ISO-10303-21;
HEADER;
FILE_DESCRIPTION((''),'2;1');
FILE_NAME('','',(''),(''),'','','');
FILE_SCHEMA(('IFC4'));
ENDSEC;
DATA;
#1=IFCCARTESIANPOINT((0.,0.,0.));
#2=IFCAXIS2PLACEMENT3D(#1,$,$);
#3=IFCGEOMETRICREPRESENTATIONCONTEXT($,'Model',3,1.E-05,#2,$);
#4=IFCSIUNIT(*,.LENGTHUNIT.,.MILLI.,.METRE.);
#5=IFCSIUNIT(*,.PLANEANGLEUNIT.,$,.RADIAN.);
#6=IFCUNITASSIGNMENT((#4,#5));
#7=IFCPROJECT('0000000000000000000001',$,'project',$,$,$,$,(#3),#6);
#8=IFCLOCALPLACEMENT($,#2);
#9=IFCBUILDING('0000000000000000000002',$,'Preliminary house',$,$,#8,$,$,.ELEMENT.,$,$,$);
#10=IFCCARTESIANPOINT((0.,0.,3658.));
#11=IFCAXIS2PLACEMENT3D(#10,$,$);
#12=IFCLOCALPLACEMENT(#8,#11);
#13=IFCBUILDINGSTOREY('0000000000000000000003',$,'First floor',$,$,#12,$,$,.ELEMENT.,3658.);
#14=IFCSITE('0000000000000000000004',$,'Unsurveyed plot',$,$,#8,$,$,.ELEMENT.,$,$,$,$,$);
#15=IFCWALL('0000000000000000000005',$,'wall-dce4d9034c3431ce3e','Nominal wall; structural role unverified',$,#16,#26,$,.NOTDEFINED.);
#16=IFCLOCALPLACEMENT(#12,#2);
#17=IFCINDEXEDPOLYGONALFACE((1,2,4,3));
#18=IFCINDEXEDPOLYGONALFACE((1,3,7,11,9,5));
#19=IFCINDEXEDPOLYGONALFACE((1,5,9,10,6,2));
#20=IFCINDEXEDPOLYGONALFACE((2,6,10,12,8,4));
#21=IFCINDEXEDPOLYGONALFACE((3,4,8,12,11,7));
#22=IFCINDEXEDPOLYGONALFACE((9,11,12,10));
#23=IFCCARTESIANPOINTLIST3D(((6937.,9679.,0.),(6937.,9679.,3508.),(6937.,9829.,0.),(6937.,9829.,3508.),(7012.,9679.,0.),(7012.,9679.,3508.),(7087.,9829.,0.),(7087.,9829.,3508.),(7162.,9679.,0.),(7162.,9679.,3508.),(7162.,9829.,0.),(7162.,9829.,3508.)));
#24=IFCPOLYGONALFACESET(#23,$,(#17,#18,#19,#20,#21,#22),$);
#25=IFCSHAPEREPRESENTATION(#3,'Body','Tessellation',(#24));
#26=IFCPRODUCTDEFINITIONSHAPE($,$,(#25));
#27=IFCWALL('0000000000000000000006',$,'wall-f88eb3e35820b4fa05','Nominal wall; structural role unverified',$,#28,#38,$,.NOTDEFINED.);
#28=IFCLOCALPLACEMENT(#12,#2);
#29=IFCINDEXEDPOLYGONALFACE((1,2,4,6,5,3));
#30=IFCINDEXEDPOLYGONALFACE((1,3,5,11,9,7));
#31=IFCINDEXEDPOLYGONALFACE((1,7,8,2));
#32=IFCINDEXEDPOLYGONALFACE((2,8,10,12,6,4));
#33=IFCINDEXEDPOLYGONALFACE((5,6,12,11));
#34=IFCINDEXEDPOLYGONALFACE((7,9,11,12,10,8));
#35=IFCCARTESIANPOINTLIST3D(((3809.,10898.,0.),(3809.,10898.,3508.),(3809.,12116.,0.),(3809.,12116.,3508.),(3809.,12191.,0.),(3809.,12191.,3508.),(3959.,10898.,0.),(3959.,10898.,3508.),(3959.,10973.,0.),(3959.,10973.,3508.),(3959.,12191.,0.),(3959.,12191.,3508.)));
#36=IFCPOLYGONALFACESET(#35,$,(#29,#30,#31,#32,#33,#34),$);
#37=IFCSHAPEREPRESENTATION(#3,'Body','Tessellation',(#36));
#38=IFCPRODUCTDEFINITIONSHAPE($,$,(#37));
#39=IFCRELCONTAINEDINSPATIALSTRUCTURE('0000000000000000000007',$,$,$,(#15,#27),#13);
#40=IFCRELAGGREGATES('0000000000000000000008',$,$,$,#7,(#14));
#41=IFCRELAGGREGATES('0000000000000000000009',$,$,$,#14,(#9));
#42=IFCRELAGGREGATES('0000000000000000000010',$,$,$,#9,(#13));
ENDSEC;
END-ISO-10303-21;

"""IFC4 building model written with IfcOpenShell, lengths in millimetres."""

from ifc_helpers import new_model, si_unit, frame, origin, place, context, project, spatial, polyline, outline, extrude, element, save


model = new_model("IFC4")

# Units and contexts
model_context = context("Model", 3, precision=1e-05, world=origin())
ifc_project = project(units=[si_unit("LENGTHUNIT", "METRE", prefix="MILLI"), si_unit("PLANEANGLEUNIT", "RADIAN")], contexts=[model_context])

# Site, building, storey
placement_1 = place(None, origin())
site = spatial("IfcSite", under=ifc_project, at=placement_1, Name="Unsurveyed plot", CompositionType="ELEMENT")
building = spatial("IfcBuilding", under=site, at=placement_1, Name="Preliminary house", CompositionType="ELEMENT")
placement_2 = place(placement_1, frame((0.0, 0.0, 3658.0)))
storey = spatial("IfcBuildingStorey", under=building, at=placement_2, Name="First floor", CompositionType="ELEMENT", Elevation=3658.0)

# Walls
element("IfcWall", 1, at=placement_2, inside=storey, Name="wall-dce4d9034c3431ce3e", Description="Nominal wall; structural role unverified", PredefinedType="NOTDEFINED", context=model_context, shape_type="SweptSolid", body=[
    extrude(outline(polyline([(7087.0, 9829.0), (7162.0, 9829.0), (7162.0, 9679.0), (7012.0, 9679.0), (6937.0, 9679.0), (6937.0, 9829.0), (7087.0, 9829.0)])), origin(), (0.0, 0.0, 1.0), 3508.0),
])
element("IfcWall", 2, at=placement_2, inside=storey, Name="wall-f88eb3e35820b4fa05", Description="Nominal wall; structural role unverified", PredefinedType="NOTDEFINED", context=model_context, shape_type="SweptSolid", body=[
    extrude(outline(polyline([(3809.0, 12116.0), (3809.0, 12191.0), (3959.0, 12191.0), (3959.0, 10973.0), (3959.0, 10898.0), (3809.0, 10898.0), (3809.0, 12116.0)])), origin(), (0.0, 0.0, 1.0), 3508.0),
])

save(model, "model.ifc")
